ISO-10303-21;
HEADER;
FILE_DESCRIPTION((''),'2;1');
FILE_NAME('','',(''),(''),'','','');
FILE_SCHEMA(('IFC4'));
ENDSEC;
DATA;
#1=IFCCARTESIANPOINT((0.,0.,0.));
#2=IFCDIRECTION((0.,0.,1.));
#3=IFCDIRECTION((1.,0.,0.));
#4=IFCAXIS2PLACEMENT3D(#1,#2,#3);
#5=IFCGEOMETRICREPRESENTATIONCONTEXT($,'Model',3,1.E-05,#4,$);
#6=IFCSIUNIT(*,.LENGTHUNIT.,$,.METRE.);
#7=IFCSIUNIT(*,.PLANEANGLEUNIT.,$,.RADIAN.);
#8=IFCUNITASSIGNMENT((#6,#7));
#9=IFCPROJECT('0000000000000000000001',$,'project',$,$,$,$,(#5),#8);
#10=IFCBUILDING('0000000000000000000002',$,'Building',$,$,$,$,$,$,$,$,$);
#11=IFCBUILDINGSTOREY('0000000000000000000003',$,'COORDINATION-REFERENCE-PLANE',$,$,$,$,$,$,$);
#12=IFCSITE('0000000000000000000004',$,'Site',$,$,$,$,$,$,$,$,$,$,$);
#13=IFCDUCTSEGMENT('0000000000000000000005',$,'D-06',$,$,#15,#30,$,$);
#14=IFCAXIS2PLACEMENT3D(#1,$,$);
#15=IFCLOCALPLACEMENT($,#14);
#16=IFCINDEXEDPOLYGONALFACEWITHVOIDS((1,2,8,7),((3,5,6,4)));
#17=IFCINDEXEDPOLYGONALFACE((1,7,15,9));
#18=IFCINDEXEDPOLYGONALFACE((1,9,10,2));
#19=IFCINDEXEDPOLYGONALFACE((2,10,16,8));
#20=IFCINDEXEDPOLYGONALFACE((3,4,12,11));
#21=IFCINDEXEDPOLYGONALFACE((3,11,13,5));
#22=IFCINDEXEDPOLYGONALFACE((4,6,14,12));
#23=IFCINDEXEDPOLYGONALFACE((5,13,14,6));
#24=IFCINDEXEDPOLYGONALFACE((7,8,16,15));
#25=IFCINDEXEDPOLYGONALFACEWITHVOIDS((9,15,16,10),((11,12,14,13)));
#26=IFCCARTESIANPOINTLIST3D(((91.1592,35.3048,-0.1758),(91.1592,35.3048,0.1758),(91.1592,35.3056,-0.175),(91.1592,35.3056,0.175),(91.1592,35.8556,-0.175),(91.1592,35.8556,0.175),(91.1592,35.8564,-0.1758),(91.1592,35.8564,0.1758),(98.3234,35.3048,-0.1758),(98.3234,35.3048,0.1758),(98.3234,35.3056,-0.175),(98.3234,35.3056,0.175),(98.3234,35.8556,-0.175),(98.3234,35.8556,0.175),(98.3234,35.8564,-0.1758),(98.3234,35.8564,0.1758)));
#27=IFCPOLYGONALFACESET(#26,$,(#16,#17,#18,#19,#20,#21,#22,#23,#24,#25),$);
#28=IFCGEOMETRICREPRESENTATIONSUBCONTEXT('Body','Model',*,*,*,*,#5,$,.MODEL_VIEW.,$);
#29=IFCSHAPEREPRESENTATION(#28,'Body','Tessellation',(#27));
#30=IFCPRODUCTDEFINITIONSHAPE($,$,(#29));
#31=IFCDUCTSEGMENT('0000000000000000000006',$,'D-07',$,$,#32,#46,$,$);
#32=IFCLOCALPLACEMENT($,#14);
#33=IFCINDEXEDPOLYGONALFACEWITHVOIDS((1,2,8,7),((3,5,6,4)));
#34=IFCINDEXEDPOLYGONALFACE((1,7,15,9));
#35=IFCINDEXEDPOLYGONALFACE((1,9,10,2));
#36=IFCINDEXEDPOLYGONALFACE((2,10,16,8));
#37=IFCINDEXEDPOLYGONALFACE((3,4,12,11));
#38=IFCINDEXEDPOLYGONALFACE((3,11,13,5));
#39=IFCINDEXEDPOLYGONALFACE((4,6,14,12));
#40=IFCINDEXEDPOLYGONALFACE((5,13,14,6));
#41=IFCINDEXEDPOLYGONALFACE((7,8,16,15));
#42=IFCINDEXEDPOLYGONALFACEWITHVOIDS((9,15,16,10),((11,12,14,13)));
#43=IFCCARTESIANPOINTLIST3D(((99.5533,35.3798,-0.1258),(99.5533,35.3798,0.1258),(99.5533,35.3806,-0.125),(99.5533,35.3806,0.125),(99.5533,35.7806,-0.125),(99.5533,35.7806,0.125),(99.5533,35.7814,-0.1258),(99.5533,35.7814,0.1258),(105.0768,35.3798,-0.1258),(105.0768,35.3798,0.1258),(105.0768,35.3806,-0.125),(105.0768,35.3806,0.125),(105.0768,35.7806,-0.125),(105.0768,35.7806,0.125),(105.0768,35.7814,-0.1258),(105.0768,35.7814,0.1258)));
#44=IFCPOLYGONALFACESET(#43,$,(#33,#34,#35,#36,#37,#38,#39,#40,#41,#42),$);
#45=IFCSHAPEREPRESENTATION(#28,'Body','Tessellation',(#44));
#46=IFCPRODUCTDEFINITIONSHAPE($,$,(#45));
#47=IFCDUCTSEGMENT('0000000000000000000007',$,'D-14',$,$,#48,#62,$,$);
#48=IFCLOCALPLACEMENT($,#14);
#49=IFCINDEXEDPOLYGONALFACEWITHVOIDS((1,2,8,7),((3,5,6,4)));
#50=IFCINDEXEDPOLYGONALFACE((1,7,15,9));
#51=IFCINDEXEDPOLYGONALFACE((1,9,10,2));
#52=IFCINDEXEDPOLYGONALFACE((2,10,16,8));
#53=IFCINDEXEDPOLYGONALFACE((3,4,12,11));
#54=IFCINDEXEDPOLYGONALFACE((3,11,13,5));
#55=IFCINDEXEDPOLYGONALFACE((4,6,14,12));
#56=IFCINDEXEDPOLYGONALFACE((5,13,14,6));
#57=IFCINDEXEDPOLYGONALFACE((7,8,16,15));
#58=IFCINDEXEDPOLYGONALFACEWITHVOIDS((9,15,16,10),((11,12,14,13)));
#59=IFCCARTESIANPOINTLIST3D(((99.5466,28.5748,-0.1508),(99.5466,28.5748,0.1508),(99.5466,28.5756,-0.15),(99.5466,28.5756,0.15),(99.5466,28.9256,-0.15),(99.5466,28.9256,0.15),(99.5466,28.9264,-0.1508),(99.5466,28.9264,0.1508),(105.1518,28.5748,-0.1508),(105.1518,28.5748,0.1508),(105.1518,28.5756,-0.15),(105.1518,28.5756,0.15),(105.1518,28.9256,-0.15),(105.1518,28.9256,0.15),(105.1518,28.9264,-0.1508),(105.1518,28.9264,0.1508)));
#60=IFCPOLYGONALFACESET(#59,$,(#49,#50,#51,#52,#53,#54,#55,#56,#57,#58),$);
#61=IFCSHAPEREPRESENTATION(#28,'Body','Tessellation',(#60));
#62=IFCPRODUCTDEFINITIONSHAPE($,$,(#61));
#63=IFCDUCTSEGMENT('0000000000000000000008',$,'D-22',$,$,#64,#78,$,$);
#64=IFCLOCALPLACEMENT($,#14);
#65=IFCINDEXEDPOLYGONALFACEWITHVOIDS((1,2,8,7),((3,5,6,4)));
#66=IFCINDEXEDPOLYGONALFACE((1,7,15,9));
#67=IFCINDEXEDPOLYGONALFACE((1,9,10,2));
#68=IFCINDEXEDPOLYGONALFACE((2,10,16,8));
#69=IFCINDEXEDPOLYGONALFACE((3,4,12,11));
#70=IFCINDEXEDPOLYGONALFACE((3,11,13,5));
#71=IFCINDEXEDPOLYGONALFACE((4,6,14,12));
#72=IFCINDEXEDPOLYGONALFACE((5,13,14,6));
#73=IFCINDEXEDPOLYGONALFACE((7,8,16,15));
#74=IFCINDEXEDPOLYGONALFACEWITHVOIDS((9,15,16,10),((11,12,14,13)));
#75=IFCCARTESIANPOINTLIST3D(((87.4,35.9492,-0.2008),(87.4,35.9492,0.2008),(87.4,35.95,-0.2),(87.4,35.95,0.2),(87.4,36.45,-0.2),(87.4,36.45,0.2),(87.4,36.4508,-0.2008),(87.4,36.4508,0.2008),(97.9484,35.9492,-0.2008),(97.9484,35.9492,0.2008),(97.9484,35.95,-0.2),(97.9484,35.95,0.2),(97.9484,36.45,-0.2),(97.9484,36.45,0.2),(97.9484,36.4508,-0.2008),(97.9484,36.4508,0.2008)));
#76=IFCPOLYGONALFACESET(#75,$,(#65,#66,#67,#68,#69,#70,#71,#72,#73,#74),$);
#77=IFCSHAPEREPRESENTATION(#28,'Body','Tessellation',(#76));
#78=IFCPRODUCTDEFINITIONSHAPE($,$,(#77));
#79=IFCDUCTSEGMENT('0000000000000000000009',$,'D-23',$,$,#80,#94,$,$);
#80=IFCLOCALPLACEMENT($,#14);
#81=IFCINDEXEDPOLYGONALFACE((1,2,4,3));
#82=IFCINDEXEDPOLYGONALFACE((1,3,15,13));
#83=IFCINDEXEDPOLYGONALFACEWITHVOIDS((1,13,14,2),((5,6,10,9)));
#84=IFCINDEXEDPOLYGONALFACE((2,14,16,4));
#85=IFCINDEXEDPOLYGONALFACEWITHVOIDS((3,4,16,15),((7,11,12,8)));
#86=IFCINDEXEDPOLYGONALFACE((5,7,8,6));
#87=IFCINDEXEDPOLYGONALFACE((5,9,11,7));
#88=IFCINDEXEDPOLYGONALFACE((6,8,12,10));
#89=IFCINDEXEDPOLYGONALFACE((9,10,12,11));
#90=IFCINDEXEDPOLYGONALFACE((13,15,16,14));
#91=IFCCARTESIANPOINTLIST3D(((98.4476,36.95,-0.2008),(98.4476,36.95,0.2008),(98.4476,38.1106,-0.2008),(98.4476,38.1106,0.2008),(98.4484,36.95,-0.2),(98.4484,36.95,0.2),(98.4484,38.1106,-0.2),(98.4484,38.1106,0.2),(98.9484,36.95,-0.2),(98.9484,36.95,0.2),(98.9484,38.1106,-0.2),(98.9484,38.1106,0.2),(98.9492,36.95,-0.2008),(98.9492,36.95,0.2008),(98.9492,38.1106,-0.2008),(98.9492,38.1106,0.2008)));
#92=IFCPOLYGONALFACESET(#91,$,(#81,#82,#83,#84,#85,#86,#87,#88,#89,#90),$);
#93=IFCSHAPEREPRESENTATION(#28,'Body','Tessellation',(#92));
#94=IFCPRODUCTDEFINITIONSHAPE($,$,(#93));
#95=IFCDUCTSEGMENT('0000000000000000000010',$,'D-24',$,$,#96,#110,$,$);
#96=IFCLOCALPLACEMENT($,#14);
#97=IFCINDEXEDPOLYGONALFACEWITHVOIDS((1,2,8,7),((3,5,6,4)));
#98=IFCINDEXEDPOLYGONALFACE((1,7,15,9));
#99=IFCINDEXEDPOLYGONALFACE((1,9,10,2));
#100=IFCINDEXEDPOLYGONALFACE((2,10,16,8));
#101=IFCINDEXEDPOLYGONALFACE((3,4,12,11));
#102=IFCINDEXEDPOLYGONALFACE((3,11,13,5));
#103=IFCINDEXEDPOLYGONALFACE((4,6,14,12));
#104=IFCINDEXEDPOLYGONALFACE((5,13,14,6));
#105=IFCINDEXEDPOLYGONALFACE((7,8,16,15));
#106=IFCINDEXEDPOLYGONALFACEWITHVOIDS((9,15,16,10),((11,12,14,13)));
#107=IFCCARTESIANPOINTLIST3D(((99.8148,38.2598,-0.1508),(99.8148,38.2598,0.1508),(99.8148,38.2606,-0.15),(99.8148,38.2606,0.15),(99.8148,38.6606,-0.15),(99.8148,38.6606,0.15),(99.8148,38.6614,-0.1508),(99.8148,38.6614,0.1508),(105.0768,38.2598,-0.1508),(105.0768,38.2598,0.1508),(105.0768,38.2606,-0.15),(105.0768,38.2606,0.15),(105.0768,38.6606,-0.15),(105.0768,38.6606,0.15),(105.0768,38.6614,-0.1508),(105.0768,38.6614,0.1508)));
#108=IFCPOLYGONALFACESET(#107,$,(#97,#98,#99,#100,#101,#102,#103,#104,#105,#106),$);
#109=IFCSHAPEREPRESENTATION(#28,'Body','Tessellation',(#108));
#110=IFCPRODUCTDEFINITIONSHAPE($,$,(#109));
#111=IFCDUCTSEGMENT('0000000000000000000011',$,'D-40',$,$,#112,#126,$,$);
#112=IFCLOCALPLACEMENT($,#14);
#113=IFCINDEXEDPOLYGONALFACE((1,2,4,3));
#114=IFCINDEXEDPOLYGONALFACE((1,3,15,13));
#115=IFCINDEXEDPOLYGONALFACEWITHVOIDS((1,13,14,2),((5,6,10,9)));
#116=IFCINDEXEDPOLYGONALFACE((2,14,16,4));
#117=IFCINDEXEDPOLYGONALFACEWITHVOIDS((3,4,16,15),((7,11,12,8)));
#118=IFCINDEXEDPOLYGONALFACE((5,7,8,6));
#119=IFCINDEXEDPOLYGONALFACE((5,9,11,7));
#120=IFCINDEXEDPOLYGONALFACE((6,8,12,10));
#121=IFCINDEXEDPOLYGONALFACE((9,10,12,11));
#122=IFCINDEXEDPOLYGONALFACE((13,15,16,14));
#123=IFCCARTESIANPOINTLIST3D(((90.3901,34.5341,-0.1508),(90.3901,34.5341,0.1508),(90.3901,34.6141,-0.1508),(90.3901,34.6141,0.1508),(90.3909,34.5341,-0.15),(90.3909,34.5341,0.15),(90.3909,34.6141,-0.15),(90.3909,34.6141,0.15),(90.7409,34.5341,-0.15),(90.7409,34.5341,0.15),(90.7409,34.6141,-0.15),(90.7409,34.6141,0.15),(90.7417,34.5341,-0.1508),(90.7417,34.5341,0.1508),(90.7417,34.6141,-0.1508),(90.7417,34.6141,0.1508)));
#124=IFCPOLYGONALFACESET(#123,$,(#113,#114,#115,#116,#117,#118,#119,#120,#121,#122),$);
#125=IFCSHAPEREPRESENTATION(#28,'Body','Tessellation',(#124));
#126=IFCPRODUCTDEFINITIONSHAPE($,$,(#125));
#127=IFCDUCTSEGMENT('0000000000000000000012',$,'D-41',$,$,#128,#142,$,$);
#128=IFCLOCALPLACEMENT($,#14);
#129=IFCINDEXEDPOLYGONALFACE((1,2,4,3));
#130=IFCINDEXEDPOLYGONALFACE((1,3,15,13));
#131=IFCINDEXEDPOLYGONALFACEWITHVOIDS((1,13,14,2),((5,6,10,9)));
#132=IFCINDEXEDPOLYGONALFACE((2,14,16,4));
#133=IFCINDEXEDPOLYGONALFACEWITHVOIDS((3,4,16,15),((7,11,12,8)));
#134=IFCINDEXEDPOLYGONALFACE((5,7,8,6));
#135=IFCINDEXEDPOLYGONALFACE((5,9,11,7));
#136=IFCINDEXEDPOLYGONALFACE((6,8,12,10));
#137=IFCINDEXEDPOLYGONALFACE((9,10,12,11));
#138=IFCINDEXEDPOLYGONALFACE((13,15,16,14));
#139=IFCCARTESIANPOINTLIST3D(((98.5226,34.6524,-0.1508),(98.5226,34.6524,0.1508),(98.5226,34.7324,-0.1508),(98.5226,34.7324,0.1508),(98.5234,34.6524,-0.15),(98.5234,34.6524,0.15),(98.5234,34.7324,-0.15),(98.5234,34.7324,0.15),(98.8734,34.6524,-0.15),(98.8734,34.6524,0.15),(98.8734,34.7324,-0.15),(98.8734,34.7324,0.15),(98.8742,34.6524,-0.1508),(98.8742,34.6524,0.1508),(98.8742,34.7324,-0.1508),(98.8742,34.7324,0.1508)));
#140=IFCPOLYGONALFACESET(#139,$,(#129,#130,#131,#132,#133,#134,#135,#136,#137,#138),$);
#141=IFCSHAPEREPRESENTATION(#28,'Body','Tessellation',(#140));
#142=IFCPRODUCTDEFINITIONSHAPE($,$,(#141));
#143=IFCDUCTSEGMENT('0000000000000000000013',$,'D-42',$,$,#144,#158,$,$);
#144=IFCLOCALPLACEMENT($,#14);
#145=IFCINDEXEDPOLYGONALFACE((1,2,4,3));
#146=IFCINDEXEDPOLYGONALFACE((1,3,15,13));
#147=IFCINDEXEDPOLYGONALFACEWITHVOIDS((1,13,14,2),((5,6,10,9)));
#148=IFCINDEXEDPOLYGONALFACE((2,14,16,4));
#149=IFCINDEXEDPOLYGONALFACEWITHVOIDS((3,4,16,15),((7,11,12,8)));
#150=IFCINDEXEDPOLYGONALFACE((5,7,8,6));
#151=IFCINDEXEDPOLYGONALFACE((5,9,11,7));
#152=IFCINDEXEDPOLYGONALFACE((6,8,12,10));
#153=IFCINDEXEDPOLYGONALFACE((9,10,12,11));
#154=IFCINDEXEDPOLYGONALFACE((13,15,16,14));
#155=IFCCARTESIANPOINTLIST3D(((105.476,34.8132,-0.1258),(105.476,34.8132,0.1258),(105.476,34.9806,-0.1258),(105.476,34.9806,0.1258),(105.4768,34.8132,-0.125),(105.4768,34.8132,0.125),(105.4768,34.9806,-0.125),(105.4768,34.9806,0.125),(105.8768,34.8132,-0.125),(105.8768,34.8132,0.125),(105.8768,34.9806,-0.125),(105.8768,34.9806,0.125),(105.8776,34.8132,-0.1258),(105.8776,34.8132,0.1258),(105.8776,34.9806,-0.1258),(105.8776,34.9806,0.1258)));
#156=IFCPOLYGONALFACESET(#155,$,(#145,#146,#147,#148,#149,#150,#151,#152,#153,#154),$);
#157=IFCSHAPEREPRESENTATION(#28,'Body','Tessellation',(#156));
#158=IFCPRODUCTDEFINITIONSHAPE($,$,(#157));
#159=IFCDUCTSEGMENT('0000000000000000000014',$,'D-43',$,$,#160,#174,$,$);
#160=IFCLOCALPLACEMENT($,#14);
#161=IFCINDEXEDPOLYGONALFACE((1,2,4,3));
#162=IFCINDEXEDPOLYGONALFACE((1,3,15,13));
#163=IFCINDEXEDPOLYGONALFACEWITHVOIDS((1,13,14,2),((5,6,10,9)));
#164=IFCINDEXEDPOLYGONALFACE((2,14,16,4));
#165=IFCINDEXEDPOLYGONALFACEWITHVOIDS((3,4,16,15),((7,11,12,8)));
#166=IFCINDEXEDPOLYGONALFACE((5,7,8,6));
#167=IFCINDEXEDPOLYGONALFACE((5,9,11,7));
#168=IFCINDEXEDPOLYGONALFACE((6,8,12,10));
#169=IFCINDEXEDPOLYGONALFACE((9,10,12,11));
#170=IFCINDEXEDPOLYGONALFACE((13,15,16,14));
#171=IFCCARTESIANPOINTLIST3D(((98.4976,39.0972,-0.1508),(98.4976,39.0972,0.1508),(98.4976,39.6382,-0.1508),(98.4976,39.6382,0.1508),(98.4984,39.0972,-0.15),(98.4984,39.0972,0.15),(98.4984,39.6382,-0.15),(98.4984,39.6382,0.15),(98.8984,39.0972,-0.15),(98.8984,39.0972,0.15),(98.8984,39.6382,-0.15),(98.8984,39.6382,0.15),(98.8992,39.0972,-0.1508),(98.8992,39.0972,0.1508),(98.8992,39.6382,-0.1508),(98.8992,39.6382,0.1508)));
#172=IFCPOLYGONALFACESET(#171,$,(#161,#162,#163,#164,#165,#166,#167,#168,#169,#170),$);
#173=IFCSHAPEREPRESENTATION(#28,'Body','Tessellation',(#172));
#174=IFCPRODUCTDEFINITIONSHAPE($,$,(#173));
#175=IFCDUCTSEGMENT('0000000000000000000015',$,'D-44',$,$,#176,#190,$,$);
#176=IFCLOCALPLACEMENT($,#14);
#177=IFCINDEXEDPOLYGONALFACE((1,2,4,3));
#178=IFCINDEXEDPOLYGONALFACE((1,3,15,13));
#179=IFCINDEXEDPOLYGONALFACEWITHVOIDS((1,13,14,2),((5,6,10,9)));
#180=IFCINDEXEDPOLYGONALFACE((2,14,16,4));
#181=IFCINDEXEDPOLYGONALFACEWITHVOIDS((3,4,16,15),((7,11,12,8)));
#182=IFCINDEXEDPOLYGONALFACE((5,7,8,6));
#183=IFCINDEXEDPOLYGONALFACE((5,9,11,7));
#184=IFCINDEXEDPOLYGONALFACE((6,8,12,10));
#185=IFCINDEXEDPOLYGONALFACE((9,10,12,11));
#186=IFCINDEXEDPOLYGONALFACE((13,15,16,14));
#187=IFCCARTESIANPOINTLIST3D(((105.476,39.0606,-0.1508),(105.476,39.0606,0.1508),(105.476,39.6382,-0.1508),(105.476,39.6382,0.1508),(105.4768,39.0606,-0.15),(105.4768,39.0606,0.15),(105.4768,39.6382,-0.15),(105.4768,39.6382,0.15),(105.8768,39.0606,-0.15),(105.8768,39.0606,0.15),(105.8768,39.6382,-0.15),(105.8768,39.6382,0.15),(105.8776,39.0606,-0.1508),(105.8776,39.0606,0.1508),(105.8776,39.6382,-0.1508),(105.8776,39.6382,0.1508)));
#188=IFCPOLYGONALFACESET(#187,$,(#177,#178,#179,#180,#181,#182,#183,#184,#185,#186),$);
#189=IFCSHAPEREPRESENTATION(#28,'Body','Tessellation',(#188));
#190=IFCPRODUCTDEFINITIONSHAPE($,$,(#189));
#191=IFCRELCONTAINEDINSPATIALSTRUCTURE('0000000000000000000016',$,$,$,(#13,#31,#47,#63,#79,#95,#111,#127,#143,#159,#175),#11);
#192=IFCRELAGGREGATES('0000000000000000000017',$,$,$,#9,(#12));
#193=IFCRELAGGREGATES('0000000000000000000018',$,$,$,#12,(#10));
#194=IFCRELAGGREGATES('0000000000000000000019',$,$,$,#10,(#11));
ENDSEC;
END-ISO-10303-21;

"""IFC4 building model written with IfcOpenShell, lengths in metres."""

from ifc_helpers import new_model, si_unit, frame, origin, origin_with_axes, place, context, subcontext, project, spatial, hollow_rectangle, extrude, element, save


model = new_model("IFC4")

# Units and contexts
model_context = context("Model", 3, precision=1e-05, world=origin_with_axes())
body_context_1 = subcontext(model_context, "Body", "Model", "MODEL_VIEW")
ifc_project = project(units=[si_unit("LENGTHUNIT", "METRE"), si_unit("PLANEANGLEUNIT", "RADIAN")], contexts=[model_context])

# Site, building, storey
site = spatial("IfcSite", under=ifc_project, Name="Site")
building = spatial("IfcBuilding", under=site, Name="Building")
storey = spatial("IfcBuildingStorey", under=building, Name="COORDINATION-REFERENCE-PLANE")

# Duct segments
duct_segment_1_placement = place(None, frame((91.1592, 35.5806, 0.0), z_axis=(1.0, 0.0, 0.0), x_axis=(0.0, 1.0, 0.0)))
element("IfcDuctSegment", 1, at=duct_segment_1_placement, inside=storey, Name="D-06", context=body_context_1, shape_type="SweptSolid", body=[
    extrude(hollow_rectangle(XDim=0.5516, YDim=0.3516, WallThickness=0.0008), origin(), (0.0, 0.0, 1.0), 7.1642),
])
duct_segment_2_placement = place(None, frame((99.5533, 35.5806, 0.0), z_axis=(1.0, 0.0, 0.0), x_axis=(0.0, 1.0, 0.0)))
element("IfcDuctSegment", 2, at=duct_segment_2_placement, inside=storey, Name="D-07", context=body_context_1, shape_type="SweptSolid", body=[
    extrude(hollow_rectangle(XDim=0.4016, YDim=0.2516, WallThickness=0.0008), origin(), (0.0, 0.0, 1.0), 5.5234),
])
duct_segment_3_placement = place(None, frame((99.5466, 28.7506, 0.0), z_axis=(1.0, 0.0, 0.0), x_axis=(0.0, 1.0, 0.0)))
element("IfcDuctSegment", 3, at=duct_segment_3_placement, inside=storey, Name="D-14", context=body_context_1, shape_type="SweptSolid", body=[
    extrude(hollow_rectangle(XDim=0.3516, YDim=0.3016, WallThickness=0.0008), origin(), (0.0, 0.0, 1.0), 5.6051),
])
duct_segment_4_placement = place(None, frame((87.4, 36.2, 0.0), z_axis=(1.0, 0.0, 0.0), x_axis=(0.0, 1.0, 0.0)))
element("IfcDuctSegment", 4, at=duct_segment_4_placement, inside=storey, Name="D-22", context=body_context_1, shape_type="SweptSolid", body=[
    extrude(hollow_rectangle(XDim=0.5016, YDim=0.4016, WallThickness=0.0008), origin(), (0.0, 0.0, 1.0), 10.5484),
])
duct_segment_5_placement = place(None, frame((98.6984, 36.95, 0.0), z_axis=(0.0, 1.0, 0.0), x_axis=(1.0, 0.0, 0.0)))
element("IfcDuctSegment", 5, at=duct_segment_5_placement, inside=storey, Name="D-23", context=body_context_1, shape_type="SweptSolid", body=[
    extrude(hollow_rectangle(XDim=0.5016, YDim=0.4016, WallThickness=0.0008), origin(), (0.0, 0.0, 1.0), 1.1606),
])
duct_segment_6_placement = place(None, frame((99.8148, 38.4606, 0.0), z_axis=(1.0, 0.0, 0.0), x_axis=(0.0, 1.0, 0.0)))
element("IfcDuctSegment", 6, at=duct_segment_6_placement, inside=storey, Name="D-24", context=body_context_1, shape_type="SweptSolid", body=[
    extrude(hollow_rectangle(XDim=0.4016, YDim=0.3016, WallThickness=0.0008), origin(), (0.0, 0.0, 1.0), 5.2619),
])
for number, where, z_axis, x_axis, name in (
    (7, (90.5659, 34.5341, 0.0), (0.0, 1.0, 0.0), (1.0, 0.0, 0.0), "D-40"),
    (8, (98.6984, 34.6524, 0.0), (0.0, 1.0, 0.0), (1.0, 0.0, 0.0), "D-41"),
):
    element("IfcDuctSegment", number, at=place(None, frame(where, z_axis=z_axis, x_axis=x_axis)), inside=storey, Name=name, context=body_context_1, shape_type="SweptSolid", body=[
        extrude(hollow_rectangle(XDim=0.3516, YDim=0.3016, WallThickness=0.0008), origin(), (0.0, 0.0, 1.0), 0.08),
    ])
duct_segment_7_placement = place(None, frame((105.6768, 34.8132, 0.0), z_axis=(0.0, 1.0, 0.0), x_axis=(1.0, 0.0, 0.0)))
element("IfcDuctSegment", 9, at=duct_segment_7_placement, inside=storey, Name="D-42", context=body_context_1, shape_type="SweptSolid", body=[
    extrude(hollow_rectangle(XDim=0.4016, YDim=0.2516, WallThickness=0.0008), origin(), (0.0, 0.0, 1.0), 0.1673),
])
duct_segment_8_placement = place(None, frame((98.6984, 39.0972, 0.0), z_axis=(0.0, 1.0, 0.0), x_axis=(1.0, 0.0, 0.0)))
element("IfcDuctSegment", 10, at=duct_segment_8_placement, inside=storey, Name="D-43", context=body_context_1, shape_type="SweptSolid", body=[
    extrude(hollow_rectangle(XDim=0.4016, YDim=0.3016, WallThickness=0.0008), origin(), (0.0, 0.0, 1.0), 0.541),
])
duct_segment_9_placement = place(None, frame((105.6768, 39.0606, 0.0), z_axis=(0.0, 1.0, 0.0), x_axis=(1.0, 0.0, 0.0)))
element("IfcDuctSegment", 11, at=duct_segment_9_placement, inside=storey, Name="D-44", context=body_context_1, shape_type="SweptSolid", body=[
    extrude(hollow_rectangle(XDim=0.4016, YDim=0.3016, WallThickness=0.0008), origin(), (0.0, 0.0, 1.0), 0.5776),
])

save(model, "model.ifc")
